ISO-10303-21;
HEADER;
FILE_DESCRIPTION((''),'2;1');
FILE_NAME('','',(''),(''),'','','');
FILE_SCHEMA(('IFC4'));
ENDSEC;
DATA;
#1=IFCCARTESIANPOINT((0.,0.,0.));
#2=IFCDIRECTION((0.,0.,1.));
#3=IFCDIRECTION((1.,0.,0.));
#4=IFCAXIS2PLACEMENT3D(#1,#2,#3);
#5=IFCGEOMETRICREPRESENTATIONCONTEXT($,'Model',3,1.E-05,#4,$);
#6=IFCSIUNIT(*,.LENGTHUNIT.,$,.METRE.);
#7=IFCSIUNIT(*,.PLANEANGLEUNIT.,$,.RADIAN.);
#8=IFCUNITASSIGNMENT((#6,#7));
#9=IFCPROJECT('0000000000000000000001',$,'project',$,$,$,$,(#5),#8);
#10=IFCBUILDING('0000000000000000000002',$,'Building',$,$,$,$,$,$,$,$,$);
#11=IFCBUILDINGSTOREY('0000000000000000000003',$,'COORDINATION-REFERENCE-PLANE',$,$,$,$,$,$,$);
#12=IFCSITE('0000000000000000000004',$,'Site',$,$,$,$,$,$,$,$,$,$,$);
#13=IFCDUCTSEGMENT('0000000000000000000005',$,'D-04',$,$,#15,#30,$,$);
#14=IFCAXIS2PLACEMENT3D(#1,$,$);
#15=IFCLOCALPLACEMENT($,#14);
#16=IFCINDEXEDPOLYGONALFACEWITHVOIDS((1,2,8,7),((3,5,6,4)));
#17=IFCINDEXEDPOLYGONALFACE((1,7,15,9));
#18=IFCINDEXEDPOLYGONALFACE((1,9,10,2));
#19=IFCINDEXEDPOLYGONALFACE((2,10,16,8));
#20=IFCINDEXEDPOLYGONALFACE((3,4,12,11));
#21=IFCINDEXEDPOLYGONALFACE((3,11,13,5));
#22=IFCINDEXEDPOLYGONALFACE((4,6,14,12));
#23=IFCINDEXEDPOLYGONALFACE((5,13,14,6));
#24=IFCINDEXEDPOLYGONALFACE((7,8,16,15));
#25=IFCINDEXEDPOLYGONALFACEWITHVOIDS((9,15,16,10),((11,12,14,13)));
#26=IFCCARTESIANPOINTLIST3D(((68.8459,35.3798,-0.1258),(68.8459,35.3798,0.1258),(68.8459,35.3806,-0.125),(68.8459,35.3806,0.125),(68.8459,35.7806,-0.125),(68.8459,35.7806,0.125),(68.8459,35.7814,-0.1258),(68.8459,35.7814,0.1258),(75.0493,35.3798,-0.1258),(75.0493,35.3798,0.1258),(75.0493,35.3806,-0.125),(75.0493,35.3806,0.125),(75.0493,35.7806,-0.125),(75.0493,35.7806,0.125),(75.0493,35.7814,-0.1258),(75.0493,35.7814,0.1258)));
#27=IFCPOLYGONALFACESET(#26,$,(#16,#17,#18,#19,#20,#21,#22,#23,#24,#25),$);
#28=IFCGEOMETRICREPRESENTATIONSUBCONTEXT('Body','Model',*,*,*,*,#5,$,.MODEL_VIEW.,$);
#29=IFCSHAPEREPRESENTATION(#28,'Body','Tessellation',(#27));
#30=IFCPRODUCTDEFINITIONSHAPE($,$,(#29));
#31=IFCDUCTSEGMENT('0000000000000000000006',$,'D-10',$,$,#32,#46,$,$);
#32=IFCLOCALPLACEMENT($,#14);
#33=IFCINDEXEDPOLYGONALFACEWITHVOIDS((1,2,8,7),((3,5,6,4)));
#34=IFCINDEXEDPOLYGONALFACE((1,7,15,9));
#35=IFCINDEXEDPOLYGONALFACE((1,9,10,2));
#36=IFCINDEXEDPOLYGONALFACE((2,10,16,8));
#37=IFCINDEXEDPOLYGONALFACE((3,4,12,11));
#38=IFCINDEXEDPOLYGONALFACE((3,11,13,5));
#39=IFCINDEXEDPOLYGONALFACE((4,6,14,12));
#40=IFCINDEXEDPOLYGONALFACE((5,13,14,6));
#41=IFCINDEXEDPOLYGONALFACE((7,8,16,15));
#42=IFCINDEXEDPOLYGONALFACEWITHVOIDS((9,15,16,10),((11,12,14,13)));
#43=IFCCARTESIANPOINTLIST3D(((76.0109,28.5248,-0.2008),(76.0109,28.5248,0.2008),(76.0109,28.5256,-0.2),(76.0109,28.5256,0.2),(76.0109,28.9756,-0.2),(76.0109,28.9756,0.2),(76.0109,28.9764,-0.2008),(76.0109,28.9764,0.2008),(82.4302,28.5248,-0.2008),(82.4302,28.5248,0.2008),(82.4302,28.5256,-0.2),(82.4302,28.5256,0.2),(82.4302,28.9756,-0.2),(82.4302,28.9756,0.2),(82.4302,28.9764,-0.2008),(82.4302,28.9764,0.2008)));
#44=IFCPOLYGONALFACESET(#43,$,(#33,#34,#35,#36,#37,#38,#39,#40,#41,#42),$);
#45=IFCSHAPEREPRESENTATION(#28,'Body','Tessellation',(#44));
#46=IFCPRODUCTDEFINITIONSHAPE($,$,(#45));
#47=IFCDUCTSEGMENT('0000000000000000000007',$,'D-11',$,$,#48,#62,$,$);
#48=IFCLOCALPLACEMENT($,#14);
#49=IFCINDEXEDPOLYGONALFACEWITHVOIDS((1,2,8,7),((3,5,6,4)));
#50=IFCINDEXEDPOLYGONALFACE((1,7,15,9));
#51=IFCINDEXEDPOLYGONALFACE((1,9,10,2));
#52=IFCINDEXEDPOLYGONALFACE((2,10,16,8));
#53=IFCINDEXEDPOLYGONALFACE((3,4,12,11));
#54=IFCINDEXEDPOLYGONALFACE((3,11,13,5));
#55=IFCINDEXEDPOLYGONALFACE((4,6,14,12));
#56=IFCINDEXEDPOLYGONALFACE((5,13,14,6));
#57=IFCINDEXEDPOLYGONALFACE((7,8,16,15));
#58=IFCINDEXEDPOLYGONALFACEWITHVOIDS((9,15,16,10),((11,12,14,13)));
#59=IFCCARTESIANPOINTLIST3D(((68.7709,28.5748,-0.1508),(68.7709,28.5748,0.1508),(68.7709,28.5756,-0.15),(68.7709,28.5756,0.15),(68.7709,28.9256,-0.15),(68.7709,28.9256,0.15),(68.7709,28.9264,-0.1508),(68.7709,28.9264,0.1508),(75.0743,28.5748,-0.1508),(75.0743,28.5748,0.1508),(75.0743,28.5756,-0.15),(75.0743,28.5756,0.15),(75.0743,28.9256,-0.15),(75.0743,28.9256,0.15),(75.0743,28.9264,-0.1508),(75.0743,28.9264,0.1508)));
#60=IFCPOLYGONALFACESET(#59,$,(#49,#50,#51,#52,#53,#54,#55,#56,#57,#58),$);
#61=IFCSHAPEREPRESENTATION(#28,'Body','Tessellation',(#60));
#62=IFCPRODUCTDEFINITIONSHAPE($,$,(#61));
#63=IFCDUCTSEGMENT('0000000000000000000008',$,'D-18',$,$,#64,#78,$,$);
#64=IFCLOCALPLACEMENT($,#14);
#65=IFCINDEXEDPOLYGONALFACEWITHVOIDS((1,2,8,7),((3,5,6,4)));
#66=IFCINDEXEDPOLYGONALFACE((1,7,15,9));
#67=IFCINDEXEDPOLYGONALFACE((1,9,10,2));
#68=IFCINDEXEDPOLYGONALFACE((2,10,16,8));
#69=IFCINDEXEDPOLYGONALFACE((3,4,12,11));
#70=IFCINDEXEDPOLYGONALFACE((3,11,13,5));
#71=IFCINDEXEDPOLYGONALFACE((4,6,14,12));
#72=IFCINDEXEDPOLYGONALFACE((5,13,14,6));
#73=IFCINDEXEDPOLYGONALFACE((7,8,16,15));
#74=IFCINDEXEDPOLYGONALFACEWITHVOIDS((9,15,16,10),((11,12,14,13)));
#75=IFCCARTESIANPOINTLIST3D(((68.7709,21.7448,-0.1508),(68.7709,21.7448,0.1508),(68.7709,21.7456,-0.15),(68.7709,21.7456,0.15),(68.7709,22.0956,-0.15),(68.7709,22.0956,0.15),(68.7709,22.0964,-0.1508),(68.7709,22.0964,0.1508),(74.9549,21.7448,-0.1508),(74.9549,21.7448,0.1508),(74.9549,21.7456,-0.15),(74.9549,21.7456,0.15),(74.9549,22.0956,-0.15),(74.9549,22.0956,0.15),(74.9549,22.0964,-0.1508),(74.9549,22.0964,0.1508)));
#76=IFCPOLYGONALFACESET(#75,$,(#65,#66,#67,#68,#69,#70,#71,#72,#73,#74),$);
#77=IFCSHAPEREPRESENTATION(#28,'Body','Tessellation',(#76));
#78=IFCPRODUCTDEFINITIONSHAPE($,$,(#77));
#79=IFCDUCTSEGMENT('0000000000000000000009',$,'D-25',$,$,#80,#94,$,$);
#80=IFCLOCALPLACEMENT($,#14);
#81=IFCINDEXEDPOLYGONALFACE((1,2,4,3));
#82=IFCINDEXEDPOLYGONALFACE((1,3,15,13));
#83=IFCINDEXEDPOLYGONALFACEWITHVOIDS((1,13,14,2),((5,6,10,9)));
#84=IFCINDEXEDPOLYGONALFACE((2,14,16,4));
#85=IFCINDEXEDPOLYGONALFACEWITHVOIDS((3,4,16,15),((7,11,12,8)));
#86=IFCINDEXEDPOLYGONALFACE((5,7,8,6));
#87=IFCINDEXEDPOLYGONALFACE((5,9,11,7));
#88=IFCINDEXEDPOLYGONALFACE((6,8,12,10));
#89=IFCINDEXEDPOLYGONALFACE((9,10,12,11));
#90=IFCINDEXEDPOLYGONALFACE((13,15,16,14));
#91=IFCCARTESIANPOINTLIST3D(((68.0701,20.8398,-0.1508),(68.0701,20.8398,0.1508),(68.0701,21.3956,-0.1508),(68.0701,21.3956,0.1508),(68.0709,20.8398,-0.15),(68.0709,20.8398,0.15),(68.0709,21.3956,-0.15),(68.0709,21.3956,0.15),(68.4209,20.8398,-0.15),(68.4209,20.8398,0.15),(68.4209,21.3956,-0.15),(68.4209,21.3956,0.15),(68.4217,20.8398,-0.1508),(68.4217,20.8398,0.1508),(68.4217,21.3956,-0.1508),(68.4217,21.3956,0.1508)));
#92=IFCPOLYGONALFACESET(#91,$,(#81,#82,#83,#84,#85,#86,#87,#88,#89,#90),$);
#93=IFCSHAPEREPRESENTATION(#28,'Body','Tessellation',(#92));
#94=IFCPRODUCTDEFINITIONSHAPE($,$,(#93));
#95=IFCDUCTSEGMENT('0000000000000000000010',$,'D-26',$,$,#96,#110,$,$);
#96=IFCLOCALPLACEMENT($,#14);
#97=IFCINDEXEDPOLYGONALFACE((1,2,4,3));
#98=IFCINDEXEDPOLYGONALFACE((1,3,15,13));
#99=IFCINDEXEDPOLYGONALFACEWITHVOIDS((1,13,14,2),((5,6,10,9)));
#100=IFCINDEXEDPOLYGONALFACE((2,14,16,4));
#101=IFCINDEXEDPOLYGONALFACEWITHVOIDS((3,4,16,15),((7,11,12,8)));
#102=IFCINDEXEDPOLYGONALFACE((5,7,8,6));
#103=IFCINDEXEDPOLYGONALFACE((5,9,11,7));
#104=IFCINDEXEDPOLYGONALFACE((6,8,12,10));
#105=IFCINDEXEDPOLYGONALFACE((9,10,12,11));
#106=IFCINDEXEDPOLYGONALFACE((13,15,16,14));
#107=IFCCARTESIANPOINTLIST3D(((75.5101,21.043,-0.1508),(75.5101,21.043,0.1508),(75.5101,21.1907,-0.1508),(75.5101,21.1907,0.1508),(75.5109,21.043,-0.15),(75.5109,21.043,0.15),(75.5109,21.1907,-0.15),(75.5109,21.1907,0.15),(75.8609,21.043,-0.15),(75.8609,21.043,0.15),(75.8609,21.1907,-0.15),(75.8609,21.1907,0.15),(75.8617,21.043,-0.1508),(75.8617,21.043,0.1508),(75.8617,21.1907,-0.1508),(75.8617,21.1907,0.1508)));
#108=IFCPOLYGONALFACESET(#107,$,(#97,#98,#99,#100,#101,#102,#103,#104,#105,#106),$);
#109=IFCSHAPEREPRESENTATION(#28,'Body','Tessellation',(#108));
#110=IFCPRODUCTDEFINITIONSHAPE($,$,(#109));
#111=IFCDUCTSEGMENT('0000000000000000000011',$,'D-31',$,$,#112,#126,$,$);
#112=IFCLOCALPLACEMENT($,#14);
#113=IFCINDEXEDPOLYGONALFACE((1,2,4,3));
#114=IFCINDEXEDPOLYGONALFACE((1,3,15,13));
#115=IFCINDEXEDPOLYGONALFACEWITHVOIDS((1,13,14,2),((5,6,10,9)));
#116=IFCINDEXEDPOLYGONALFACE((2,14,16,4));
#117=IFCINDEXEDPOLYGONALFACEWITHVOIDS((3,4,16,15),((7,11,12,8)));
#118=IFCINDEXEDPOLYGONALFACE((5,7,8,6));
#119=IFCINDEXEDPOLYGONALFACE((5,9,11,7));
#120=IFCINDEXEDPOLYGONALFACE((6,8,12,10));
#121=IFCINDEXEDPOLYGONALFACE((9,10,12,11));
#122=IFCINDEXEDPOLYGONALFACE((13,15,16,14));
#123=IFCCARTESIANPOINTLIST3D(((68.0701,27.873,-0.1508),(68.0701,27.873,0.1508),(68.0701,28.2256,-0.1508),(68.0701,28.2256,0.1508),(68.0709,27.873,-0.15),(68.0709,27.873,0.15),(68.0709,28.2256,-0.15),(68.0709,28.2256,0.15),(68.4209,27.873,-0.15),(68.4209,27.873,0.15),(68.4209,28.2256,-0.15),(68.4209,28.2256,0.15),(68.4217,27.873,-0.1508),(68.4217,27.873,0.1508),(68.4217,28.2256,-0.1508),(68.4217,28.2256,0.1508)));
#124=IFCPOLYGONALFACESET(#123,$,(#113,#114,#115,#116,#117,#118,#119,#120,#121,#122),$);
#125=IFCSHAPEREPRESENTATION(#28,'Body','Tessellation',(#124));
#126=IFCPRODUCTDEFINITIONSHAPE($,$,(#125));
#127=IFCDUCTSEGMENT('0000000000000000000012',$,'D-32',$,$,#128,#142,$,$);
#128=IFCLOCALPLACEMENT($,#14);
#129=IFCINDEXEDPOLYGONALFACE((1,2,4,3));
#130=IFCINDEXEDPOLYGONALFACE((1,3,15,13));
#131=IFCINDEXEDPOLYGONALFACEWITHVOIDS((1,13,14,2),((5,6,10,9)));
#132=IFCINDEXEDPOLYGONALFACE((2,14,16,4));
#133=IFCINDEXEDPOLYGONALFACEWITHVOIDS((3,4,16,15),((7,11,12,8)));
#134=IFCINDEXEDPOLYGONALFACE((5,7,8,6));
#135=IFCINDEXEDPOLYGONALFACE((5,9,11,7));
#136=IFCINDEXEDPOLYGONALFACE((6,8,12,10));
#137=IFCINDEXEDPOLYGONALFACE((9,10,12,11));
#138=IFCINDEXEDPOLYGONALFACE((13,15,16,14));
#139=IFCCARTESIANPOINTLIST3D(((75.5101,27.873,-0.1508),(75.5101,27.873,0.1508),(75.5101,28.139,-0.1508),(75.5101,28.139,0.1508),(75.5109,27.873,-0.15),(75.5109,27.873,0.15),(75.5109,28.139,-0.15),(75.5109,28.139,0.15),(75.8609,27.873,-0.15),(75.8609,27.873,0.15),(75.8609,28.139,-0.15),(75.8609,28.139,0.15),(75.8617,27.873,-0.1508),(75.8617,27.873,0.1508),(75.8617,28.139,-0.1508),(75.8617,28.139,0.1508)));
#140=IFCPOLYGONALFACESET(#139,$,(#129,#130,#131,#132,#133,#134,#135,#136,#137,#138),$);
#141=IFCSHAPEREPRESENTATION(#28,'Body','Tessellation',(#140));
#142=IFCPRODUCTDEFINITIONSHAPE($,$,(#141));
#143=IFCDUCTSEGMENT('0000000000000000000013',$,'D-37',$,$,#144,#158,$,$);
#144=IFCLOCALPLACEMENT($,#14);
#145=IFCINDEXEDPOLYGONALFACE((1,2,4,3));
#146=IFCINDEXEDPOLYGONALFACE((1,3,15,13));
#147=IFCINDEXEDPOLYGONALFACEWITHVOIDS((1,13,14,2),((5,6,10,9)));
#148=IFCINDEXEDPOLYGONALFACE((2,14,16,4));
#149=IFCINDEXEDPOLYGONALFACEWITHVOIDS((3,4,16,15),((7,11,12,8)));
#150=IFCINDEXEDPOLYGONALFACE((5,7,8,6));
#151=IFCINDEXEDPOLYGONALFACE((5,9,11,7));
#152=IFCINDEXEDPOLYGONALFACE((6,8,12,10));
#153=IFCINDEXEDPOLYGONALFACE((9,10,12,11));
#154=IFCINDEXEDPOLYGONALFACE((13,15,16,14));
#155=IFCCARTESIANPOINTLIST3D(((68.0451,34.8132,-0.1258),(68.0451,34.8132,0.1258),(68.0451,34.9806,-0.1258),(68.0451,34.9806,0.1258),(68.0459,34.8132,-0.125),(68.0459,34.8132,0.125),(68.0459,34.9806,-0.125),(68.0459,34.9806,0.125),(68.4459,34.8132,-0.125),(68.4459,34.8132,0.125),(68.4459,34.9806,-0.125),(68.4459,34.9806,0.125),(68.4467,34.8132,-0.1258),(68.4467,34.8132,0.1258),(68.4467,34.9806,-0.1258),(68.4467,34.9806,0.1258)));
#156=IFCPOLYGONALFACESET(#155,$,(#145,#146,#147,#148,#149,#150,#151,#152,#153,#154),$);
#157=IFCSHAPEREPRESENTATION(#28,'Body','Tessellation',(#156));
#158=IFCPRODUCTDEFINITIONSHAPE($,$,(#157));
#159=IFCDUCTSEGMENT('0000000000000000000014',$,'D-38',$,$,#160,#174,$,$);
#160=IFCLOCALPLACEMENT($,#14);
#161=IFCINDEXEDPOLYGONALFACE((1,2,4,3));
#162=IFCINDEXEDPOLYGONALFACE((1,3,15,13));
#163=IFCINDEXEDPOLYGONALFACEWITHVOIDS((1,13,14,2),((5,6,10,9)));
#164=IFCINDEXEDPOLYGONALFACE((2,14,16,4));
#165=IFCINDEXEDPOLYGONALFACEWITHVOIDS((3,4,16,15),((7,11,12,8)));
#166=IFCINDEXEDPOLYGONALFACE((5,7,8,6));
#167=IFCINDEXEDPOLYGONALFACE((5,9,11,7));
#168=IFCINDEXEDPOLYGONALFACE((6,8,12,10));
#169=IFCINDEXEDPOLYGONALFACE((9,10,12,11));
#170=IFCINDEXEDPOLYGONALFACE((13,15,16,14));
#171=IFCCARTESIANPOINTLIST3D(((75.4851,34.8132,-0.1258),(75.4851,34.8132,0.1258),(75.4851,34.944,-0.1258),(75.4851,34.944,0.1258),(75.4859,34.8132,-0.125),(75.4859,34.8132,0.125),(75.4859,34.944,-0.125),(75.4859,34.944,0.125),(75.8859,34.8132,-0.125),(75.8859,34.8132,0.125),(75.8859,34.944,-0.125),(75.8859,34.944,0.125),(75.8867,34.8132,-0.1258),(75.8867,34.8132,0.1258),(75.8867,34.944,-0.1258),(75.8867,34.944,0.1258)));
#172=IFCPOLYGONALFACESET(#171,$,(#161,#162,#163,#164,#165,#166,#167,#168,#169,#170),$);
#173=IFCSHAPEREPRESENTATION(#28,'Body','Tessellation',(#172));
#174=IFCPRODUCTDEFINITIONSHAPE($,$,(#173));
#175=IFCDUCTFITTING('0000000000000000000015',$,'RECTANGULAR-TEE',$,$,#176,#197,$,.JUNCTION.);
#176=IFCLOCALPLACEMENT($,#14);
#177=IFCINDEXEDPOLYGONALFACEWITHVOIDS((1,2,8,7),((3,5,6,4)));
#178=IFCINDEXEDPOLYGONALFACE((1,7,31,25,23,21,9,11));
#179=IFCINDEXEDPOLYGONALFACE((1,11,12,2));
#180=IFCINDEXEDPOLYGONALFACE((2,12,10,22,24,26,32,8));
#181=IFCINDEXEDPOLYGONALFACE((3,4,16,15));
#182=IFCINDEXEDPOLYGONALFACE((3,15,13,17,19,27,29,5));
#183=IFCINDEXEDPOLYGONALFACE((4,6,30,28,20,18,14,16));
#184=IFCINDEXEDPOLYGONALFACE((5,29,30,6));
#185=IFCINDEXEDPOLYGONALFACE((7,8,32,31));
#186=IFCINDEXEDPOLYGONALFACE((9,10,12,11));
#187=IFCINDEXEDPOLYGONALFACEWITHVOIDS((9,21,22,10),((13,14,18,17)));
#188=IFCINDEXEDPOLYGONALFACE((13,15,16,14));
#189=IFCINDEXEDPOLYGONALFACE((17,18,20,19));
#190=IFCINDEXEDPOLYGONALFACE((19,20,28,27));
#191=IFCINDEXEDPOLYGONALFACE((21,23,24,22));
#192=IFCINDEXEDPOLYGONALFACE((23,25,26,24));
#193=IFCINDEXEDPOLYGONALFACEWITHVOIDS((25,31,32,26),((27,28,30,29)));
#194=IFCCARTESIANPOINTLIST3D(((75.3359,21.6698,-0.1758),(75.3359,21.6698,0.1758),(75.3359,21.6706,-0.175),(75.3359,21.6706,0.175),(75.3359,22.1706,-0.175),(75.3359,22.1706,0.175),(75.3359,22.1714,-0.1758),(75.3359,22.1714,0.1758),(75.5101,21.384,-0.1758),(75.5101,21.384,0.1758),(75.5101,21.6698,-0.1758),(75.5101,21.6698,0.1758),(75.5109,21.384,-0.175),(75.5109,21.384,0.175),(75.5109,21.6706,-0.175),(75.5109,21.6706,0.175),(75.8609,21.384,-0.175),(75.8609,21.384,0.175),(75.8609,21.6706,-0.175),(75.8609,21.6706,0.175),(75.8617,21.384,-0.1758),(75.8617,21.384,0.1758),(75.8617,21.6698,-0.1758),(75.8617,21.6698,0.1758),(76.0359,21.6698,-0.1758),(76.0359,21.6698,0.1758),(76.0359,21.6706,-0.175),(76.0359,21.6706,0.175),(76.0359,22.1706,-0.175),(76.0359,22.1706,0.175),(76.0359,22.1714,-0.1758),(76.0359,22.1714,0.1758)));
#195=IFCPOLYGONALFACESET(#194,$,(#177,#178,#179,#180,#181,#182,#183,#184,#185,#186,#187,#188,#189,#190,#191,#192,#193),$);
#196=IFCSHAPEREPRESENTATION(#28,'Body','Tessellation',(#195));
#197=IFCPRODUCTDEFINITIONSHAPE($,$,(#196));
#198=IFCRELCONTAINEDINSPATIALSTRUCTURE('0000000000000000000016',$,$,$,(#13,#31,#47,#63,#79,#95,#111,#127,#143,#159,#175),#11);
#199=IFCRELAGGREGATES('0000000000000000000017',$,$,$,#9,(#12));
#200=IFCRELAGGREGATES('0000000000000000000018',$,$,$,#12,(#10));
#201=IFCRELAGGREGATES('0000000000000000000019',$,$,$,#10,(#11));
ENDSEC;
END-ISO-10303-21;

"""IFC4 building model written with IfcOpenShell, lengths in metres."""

from ifc_helpers import new_model, si_unit, frame, origin, origin_with_axes, place, context, subcontext, project, spatial, rectangle, hollow_rectangle, extrude, boolean, element, save


model = new_model("IFC4")

# Units and contexts
model_context = context("Model", 3, precision=1e-05, world=origin_with_axes())
body_context_1 = subcontext(model_context, "Body", "Model", "MODEL_VIEW")
ifc_project = project(units=[si_unit("LENGTHUNIT", "METRE"), si_unit("PLANEANGLEUNIT", "RADIAN")], contexts=[model_context])

# Site, building, storey
site = spatial("IfcSite", under=ifc_project, Name="Site")
building = spatial("IfcBuilding", under=site, Name="Building")
storey = spatial("IfcBuildingStorey", under=building, Name="COORDINATION-REFERENCE-PLANE")

# Duct segments
duct_segment_1_placement = place(None, frame((68.8459, 35.5806, 0.0), z_axis=(1.0, 0.0, 0.0), x_axis=(0.0, 1.0, 0.0)))
element("IfcDuctSegment", 1, at=duct_segment_1_placement, inside=storey, Name="D-04", context=body_context_1, shape_type="SweptSolid", body=[
    extrude(hollow_rectangle(XDim=0.4016, YDim=0.2516, WallThickness=0.0008), origin(), (0.0, 0.0, 1.0), 6.2034),
])
duct_segment_2_placement = place(None, frame((76.0109, 28.7506, 0.0), z_axis=(1.0, 0.0, 0.0), x_axis=(0.0, 1.0, 0.0)))
element("IfcDuctSegment", 2, at=duct_segment_2_placement, inside=storey, Name="D-10", context=body_context_1, shape_type="SweptSolid", body=[
    extrude(hollow_rectangle(XDim=0.4516, YDim=0.4016, WallThickness=0.0008), origin(), (0.0, 0.0, 1.0), 6.4193),
])
duct_segment_3_placement = place(None, frame((68.7709, 28.7506, 0.0), z_axis=(1.0, 0.0, 0.0), x_axis=(0.0, 1.0, 0.0)))
element("IfcDuctSegment", 3, at=duct_segment_3_placement, inside=storey, Name="D-11", context=body_context_1, shape_type="SweptSolid", body=[
    extrude(hollow_rectangle(XDim=0.3516, YDim=0.3016, WallThickness=0.0008), origin(), (0.0, 0.0, 1.0), 6.3034),
])
duct_segment_4_placement = place(None, frame((68.7709, 21.9206, 0.0), z_axis=(1.0, 0.0, 0.0), x_axis=(0.0, 1.0, 0.0)))
element("IfcDuctSegment", 4, at=duct_segment_4_placement, inside=storey, Name="D-18", context=body_context_1, shape_type="SweptSolid", body=[
    extrude(hollow_rectangle(XDim=0.3516, YDim=0.3016, WallThickness=0.0008), origin(), (0.0, 0.0, 1.0), 6.1839),
])
duct_segment_5_placement = place(None, frame((68.2459, 20.8398, 0.0), z_axis=(0.0, 1.0, 0.0), x_axis=(1.0, 0.0, 0.0)))
element("IfcDuctSegment", 5, at=duct_segment_5_placement, inside=storey, Name="D-25", context=body_context_1, shape_type="SweptSolid", body=[
    extrude(hollow_rectangle(XDim=0.3516, YDim=0.3016, WallThickness=0.0008), origin(), (0.0, 0.0, 1.0), 0.5558),
])
duct_segment_6_placement = place(None, frame((75.6859, 21.043, 0.0), z_axis=(0.0, 1.0, 0.0), x_axis=(1.0, 0.0, 0.0)))
element("IfcDuctSegment", 6, at=duct_segment_6_placement, inside=storey, Name="D-26", context=body_context_1, shape_type="SweptSolid", body=[
    extrude(hollow_rectangle(XDim=0.3516, YDim=0.3016, WallThickness=0.0008), origin(), (0.0, 0.0, 1.0), 0.1477),
])
duct_segment_7_placement = place(None, frame((68.2459, 27.873, 0.0), z_axis=(0.0, 1.0, 0.0), x_axis=(1.0, 0.0, 0.0)))
element("IfcDuctSegment", 7, at=duct_segment_7_placement, inside=storey, Name="D-31", context=body_context_1, shape_type="SweptSolid", body=[
    extrude(hollow_rectangle(XDim=0.3516, YDim=0.3016, WallThickness=0.0008), origin(), (0.0, 0.0, 1.0), 0.3526),
])
duct_segment_8_placement = place(None, frame((75.6859, 27.873, 0.0), z_axis=(0.0, 1.0, 0.0), x_axis=(1.0, 0.0, 0.0)))
element("IfcDuctSegment", 8, at=duct_segment_8_placement, inside=storey, Name="D-32", context=body_context_1, shape_type="SweptSolid", body=[
    extrude(hollow_rectangle(XDim=0.3516, YDim=0.3016, WallThickness=0.0008), origin(), (0.0, 0.0, 1.0), 0.266),
])
duct_segment_9_placement = place(None, frame((68.2459, 34.8132, 0.0), z_axis=(0.0, 1.0, 0.0), x_axis=(1.0, 0.0, 0.0)))
element("IfcDuctSegment", 9, at=duct_segment_9_placement, inside=storey, Name="D-37", context=body_context_1, shape_type="SweptSolid", body=[
    extrude(hollow_rectangle(XDim=0.4016, YDim=0.2516, WallThickness=0.0008), origin(), (0.0, 0.0, 1.0), 0.1673),
])
duct_segment_10_placement = place(None, frame((75.6859, 34.8132, 0.0), z_axis=(0.0, 1.0, 0.0), x_axis=(1.0, 0.0, 0.0)))
element("IfcDuctSegment", 10, at=duct_segment_10_placement, inside=storey, Name="D-38", context=body_context_1, shape_type="SweptSolid", body=[
    extrude(hollow_rectangle(XDim=0.4016, YDim=0.2516, WallThickness=0.0008), origin(), (0.0, 0.0, 1.0), 0.1307),
])

# Duct fitting
duct_fitting_1_placement = place(None, frame((75.6859, 21.9206, 0.0), z_axis=(-1.0, 0.0, 0.0), x_axis=(0.0, -1.0, 0.0)))
solid_1 = boolean("UNION", extrude(rectangle(XDim=0.5, YDim=0.35), frame((0.0, 0.0, -0.35), z_axis=(0.0, 0.0, 1.0), x_axis=(1.0, 0.0, 0.0)), (0.0, 0.0, 1.0), 0.7), extrude(rectangle(XDim=0.35, YDim=0.35), frame((0.0, 0.0, 0.0), z_axis=(1.0, 0.0, 0.0), x_axis=(0.0, 0.0, -1.0)), (0.0, 0.0, 1.0), 0.5366))
element("IfcDuctFitting", 11, at=duct_fitting_1_placement, inside=storey, Name="RECTANGULAR-TEE", PredefinedType="JUNCTION", context=body_context_1, shape_type="CSG", body=[
    boolean("DIFFERENCE", boolean("UNION", extrude(rectangle(XDim=0.5016, YDim=0.3516), frame((0.0, 0.0, -0.35), z_axis=(0.0, 0.0, 1.0), x_axis=(1.0, 0.0, 0.0)), (0.0, 0.0, 1.0), 0.7), extrude(rectangle(XDim=0.3516, YDim=0.3516), frame((0.0, 0.0, 0.0), z_axis=(1.0, 0.0, 0.0), x_axis=(0.0, 0.0, -1.0)), (0.0, 0.0, 1.0), 0.5366)), solid_1),
])

save(model, "model.ifc")
